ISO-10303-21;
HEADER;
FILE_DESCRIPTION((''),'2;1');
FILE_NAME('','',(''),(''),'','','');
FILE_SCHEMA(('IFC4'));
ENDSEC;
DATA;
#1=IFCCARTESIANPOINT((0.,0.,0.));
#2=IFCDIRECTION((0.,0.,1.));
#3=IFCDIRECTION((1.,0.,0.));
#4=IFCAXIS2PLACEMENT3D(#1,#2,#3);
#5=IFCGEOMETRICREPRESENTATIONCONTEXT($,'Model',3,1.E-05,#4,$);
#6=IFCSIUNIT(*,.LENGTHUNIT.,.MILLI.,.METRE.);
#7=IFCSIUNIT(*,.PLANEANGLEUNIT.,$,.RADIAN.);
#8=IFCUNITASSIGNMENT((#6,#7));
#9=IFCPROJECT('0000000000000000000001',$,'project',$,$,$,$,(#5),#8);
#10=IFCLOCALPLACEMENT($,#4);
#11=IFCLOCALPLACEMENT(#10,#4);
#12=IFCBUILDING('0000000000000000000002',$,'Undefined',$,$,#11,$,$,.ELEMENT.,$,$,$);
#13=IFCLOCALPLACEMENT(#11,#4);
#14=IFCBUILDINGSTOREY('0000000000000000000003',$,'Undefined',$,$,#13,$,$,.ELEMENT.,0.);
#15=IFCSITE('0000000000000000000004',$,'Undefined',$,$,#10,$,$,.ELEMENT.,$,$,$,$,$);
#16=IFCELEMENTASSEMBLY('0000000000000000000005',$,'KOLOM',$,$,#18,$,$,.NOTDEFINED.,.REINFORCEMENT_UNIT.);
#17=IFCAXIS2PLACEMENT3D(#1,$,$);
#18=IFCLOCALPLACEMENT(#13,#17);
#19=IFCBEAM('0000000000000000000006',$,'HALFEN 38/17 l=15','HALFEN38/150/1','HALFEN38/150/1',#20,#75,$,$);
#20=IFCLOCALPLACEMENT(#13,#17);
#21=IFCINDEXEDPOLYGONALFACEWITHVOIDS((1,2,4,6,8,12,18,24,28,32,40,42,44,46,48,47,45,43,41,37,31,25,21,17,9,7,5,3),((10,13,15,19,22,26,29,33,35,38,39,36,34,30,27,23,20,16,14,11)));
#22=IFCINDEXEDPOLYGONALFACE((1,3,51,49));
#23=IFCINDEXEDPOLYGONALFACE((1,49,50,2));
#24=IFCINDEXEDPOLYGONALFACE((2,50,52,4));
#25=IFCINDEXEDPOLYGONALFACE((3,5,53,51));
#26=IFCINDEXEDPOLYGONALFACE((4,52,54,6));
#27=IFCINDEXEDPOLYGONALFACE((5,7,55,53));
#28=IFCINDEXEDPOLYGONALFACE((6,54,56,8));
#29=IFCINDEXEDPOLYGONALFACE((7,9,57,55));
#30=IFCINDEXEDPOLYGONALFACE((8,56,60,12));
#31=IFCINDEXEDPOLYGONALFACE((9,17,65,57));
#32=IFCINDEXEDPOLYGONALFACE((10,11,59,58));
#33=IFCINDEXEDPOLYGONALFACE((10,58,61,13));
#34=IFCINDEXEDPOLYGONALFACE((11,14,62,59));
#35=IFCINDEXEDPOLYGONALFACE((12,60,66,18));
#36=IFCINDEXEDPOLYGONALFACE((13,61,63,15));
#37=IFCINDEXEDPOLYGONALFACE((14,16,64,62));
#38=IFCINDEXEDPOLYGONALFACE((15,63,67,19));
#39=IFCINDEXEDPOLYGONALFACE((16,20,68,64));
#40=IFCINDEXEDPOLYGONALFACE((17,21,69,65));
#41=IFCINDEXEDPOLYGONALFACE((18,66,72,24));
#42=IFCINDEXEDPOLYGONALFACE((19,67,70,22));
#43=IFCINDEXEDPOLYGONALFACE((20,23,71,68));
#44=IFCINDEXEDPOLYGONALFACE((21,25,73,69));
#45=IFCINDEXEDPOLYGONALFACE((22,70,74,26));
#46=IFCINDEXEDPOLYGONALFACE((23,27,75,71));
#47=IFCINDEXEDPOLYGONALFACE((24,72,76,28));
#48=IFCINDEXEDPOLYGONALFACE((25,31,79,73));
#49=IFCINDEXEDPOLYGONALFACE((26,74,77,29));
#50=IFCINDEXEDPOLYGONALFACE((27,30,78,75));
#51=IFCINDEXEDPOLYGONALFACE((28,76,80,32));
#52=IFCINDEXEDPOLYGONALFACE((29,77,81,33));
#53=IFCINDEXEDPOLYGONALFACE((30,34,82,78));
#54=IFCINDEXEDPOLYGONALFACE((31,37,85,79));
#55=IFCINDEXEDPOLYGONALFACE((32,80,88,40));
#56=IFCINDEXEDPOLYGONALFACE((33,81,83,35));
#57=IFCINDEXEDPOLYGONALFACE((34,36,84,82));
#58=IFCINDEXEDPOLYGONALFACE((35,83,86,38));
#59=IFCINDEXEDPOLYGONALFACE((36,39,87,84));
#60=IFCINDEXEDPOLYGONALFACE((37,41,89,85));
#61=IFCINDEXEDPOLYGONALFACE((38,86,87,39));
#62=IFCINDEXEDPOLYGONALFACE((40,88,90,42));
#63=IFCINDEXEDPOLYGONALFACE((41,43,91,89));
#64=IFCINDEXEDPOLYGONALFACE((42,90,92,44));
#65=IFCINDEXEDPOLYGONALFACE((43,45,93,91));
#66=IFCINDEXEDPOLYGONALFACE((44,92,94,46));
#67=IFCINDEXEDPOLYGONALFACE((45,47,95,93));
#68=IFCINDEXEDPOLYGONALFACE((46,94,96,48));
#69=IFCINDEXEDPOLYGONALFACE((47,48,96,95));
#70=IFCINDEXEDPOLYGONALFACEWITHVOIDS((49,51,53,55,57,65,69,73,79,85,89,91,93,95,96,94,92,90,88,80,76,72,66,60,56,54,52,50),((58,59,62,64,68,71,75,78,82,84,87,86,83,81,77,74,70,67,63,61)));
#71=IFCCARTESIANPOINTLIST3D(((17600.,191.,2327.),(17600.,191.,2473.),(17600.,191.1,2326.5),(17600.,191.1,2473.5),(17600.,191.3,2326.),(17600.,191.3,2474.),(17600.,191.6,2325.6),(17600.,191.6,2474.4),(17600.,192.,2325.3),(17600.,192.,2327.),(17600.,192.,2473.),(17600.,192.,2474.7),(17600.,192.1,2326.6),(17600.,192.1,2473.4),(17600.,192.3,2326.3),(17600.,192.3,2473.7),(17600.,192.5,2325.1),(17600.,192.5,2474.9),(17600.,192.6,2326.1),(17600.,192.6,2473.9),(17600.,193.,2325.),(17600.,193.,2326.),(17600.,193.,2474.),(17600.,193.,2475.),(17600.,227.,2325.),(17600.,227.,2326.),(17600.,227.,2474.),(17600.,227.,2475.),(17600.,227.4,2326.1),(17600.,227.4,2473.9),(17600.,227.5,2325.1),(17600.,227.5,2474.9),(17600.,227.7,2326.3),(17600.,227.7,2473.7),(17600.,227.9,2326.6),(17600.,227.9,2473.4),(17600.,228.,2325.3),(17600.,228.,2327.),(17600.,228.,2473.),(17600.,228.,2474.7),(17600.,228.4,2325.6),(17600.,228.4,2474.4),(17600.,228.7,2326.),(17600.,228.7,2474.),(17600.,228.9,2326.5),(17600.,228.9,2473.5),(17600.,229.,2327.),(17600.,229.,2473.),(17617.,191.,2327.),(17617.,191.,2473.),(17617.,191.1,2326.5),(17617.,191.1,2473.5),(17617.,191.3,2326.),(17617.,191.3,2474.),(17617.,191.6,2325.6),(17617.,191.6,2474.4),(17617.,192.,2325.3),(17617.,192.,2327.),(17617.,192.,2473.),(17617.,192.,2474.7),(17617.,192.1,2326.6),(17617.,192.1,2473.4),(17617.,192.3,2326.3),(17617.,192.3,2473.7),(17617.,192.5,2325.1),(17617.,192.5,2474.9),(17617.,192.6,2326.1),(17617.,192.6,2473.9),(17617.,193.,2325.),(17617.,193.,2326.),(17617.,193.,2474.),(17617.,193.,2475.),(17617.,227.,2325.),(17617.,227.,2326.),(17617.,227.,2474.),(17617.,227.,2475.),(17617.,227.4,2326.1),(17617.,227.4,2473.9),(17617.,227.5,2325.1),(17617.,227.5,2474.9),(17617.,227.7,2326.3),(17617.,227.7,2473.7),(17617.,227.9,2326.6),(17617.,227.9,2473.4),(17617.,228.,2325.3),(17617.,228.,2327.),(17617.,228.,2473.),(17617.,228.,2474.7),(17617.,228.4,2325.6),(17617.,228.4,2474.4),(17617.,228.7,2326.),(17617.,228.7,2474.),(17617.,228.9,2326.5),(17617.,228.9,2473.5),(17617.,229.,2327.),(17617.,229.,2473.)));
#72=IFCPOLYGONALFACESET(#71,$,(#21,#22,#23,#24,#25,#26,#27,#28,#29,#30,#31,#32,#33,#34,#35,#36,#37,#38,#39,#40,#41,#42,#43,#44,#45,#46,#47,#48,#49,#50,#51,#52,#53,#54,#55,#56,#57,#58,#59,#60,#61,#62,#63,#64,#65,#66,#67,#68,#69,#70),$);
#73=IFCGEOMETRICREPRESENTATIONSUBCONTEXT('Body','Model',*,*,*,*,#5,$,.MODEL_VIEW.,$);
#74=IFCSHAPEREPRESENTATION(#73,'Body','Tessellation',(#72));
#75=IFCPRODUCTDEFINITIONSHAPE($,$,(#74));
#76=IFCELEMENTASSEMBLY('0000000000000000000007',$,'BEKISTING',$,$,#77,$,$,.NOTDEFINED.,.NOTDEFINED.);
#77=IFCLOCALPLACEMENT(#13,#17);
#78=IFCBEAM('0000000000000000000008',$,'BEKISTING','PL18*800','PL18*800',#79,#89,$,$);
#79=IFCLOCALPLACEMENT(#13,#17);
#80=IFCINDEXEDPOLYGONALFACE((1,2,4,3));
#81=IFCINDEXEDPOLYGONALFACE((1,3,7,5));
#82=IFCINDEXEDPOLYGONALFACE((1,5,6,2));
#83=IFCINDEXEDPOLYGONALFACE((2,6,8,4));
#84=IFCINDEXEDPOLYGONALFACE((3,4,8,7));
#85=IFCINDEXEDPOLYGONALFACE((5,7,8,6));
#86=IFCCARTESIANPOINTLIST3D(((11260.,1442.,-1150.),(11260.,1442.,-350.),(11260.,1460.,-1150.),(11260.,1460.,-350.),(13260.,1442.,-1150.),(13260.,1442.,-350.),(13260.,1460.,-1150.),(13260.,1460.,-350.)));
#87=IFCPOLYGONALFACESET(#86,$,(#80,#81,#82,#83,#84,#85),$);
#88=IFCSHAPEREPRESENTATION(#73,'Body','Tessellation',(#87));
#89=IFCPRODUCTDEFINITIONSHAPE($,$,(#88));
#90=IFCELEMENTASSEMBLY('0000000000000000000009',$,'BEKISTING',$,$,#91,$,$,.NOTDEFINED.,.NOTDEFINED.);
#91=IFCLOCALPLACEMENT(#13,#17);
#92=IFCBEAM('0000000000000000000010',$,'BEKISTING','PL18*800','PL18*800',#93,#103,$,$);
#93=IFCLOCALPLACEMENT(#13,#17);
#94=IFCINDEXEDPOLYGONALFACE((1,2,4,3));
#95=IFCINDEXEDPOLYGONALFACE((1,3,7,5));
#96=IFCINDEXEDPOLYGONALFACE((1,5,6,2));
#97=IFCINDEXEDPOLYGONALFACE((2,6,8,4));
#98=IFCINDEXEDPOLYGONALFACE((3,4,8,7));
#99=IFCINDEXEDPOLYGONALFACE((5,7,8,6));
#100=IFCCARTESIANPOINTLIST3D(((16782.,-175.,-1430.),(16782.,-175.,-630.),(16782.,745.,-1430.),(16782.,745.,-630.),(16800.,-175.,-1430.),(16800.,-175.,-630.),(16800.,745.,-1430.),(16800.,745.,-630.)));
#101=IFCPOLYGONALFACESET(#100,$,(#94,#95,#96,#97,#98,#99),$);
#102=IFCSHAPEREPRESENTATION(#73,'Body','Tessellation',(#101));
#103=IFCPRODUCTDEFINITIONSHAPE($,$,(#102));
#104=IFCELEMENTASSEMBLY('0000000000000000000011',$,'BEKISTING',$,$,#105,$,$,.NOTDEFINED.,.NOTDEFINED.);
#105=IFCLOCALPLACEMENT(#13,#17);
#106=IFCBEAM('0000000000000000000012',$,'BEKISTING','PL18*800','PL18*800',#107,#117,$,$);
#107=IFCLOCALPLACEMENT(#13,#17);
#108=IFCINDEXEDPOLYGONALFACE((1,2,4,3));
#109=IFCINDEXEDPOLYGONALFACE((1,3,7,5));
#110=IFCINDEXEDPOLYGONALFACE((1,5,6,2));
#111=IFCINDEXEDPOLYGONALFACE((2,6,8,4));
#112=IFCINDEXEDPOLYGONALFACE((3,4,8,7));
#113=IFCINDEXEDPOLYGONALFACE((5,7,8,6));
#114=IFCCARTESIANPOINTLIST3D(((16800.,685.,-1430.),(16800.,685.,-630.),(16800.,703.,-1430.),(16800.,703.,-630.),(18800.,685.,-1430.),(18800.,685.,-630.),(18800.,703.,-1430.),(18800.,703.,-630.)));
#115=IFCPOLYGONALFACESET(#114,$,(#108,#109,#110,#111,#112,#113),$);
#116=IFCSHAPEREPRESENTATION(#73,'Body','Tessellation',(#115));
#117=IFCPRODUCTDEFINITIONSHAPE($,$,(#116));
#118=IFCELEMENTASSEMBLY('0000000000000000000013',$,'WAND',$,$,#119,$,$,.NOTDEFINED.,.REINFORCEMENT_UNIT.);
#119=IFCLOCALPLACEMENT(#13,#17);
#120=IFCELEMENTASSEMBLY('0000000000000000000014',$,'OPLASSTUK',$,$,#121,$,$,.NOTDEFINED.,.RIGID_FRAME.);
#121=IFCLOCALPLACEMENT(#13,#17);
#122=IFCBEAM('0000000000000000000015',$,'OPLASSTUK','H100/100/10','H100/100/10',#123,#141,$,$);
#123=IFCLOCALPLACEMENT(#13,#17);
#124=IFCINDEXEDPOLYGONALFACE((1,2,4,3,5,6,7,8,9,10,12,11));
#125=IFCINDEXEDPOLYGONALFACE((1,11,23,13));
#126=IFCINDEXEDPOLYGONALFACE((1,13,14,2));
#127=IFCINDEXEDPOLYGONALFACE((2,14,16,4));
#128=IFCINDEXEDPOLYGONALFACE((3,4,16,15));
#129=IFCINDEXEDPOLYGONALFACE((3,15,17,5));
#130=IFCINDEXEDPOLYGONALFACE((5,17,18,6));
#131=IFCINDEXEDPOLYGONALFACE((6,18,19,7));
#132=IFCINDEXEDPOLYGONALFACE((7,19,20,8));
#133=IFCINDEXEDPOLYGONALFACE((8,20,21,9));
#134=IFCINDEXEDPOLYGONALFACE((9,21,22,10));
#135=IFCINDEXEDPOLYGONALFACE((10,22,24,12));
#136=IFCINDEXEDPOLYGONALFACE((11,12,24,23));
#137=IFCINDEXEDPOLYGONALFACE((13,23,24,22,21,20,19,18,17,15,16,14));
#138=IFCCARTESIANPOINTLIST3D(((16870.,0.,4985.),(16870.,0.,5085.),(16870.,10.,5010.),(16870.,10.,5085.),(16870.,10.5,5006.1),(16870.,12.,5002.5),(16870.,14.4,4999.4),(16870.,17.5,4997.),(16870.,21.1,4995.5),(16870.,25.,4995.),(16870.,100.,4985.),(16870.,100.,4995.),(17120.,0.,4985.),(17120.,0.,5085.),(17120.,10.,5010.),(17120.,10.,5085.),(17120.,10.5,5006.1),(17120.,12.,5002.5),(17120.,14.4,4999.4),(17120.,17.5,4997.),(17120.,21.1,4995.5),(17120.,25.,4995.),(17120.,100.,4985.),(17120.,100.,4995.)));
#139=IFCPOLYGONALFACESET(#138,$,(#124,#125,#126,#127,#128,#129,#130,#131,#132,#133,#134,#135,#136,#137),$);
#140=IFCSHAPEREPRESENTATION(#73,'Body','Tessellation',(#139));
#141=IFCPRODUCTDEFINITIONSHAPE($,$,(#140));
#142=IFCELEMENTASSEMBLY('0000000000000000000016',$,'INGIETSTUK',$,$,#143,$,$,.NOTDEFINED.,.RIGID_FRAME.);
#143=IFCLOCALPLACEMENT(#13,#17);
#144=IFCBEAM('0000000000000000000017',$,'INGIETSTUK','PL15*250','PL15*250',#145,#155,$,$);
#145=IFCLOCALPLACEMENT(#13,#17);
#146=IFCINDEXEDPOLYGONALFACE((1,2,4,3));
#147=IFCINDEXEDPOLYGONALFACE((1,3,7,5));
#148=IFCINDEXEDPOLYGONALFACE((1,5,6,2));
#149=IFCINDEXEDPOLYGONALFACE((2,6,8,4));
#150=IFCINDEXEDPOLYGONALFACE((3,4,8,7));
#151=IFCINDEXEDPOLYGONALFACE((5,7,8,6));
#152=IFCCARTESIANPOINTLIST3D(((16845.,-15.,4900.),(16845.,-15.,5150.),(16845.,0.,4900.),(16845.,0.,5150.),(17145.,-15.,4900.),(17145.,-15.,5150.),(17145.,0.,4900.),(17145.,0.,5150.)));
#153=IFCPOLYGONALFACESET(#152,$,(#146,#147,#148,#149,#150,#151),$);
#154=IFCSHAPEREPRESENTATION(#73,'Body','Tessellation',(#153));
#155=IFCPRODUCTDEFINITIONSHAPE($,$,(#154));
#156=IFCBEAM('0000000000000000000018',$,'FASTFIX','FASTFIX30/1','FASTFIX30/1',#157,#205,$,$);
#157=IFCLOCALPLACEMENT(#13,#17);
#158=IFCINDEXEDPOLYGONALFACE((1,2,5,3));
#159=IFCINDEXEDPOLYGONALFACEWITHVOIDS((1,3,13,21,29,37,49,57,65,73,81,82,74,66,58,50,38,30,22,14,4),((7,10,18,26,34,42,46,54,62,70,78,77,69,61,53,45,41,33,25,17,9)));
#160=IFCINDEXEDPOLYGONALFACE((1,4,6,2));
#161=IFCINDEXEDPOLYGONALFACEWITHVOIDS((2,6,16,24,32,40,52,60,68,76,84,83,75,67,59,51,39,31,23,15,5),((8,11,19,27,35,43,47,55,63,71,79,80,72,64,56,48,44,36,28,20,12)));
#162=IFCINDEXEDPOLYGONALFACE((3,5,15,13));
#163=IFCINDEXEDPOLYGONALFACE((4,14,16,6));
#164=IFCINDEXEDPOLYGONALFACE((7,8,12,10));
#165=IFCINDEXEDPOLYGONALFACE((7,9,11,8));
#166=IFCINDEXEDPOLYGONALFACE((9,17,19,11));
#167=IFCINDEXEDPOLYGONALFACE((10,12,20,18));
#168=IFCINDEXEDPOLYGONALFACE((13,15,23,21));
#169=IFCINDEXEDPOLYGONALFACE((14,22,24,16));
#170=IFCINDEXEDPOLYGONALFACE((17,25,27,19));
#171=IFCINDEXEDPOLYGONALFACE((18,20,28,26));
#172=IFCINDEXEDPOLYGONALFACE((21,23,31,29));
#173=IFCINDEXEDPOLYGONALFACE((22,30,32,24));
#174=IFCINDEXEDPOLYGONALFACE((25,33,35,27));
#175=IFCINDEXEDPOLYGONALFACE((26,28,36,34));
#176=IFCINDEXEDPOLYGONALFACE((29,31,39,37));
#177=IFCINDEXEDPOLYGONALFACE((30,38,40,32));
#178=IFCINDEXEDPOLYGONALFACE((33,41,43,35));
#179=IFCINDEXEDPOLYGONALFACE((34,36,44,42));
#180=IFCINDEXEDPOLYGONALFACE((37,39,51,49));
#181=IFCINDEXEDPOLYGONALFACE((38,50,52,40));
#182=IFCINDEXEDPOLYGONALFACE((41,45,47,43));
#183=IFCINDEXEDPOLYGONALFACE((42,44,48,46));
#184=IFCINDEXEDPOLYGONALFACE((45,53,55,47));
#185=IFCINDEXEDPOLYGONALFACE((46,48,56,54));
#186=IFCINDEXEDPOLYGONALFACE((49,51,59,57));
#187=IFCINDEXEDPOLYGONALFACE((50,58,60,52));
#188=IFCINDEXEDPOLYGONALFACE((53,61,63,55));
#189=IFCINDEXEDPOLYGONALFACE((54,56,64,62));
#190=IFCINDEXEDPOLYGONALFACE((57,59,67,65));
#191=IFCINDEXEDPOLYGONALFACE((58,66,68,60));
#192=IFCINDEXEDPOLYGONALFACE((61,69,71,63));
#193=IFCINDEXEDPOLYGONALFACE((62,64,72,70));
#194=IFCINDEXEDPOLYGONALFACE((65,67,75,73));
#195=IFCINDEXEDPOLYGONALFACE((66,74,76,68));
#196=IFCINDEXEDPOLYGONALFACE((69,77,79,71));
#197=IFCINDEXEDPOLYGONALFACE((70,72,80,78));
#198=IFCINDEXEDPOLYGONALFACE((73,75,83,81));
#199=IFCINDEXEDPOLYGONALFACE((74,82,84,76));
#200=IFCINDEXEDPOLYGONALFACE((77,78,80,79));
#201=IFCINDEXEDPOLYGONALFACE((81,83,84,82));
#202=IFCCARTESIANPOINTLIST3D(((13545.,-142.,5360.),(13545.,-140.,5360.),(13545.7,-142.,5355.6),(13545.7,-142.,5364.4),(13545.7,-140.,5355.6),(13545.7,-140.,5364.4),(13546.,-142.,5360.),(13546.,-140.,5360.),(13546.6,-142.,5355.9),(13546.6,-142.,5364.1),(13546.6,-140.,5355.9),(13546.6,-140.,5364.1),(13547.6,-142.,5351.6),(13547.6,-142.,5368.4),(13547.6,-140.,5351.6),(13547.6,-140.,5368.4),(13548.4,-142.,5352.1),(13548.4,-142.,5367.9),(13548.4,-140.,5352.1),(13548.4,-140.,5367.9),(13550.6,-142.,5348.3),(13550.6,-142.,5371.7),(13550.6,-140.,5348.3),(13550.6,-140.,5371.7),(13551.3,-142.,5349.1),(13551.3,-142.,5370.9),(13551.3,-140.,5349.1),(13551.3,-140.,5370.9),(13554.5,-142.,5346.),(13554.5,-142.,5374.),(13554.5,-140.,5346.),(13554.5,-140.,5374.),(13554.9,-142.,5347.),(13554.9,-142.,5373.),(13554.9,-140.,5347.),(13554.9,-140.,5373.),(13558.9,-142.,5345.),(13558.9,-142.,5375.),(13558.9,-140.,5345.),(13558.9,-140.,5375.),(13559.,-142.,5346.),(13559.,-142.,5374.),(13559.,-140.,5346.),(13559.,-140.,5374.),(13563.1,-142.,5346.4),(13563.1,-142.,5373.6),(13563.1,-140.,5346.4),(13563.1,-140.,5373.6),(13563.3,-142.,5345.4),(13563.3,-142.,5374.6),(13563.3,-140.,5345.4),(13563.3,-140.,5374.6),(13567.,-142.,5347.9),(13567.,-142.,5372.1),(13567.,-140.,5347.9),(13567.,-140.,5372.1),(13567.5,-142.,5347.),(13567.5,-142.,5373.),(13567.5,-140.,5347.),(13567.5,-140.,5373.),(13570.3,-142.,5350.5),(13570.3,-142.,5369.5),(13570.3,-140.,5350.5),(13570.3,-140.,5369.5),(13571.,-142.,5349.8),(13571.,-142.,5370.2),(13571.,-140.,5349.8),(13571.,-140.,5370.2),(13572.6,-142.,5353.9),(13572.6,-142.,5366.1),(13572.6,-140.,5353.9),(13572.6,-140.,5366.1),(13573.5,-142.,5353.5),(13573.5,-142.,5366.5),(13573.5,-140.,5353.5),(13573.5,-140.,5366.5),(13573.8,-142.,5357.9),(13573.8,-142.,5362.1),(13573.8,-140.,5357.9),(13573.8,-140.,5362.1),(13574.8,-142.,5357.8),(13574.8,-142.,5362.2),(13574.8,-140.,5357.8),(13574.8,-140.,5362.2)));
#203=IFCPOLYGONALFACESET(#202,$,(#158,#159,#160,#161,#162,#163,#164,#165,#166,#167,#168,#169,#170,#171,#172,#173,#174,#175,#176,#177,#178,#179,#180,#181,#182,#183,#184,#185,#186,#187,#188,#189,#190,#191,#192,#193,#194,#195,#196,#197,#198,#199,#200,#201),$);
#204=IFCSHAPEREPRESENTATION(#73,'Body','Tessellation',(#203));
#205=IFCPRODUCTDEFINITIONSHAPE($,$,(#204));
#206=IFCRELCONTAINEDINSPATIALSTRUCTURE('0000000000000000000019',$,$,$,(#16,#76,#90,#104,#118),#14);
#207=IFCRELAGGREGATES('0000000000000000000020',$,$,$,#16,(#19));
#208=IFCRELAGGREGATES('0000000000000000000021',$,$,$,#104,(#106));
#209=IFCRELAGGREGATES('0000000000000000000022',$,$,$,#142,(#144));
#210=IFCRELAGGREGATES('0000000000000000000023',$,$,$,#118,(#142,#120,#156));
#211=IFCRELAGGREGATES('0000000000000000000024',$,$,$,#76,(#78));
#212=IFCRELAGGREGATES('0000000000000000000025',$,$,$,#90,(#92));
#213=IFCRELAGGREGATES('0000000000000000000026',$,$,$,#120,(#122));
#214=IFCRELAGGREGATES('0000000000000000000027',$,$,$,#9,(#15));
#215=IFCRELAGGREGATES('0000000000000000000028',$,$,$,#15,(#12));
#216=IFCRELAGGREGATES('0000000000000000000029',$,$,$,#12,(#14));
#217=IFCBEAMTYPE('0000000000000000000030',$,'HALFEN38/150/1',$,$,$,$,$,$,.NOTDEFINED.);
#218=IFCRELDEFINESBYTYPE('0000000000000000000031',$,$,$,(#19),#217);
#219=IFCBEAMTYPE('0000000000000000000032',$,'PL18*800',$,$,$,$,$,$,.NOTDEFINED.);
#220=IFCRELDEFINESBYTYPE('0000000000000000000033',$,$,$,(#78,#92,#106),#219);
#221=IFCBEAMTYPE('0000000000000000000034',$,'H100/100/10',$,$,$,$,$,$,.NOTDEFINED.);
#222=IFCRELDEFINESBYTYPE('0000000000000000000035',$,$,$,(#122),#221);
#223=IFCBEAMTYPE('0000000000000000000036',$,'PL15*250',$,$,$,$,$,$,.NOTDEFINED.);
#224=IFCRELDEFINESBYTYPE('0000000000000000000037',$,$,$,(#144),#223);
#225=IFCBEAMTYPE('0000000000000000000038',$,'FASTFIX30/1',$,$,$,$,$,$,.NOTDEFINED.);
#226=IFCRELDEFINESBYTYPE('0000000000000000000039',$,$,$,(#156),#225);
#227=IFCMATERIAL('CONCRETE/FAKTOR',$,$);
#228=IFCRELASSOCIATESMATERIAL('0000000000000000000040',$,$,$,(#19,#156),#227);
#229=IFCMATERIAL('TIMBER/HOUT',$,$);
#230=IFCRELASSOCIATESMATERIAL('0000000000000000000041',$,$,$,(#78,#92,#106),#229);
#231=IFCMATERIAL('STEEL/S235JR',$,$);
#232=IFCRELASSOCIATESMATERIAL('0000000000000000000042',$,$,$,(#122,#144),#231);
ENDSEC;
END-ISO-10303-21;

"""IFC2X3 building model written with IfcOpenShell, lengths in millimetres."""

from ifc_helpers import new_model, si_unit, frame, frame_2d, origin_with_axes, place, context, subcontext, project, spatial, rectangle, hollow_rectangle, hollow_circle, l_section, extrude, material, type_object, element, aggregate, save


model = new_model("IFC2X3")

# Units and contexts
model_context = context("Model", 3, precision=1e-05, world=origin_with_axes())
body_context = subcontext(model_context, "Body", "Model", "MODEL_VIEW")
ifc_project = project(units=[si_unit("LENGTHUNIT", "METRE", prefix="MILLI"), si_unit("PLANEANGLEUNIT", "RADIAN")], contexts=[model_context])

# Site, building, storey
site_placement = place(None, origin_with_axes())
site = spatial("IfcSite", under=ifc_project, at=site_placement, Name="Undefined", CompositionType="ELEMENT")
building_placement = place(site_placement, origin_with_axes())
building = spatial("IfcBuilding", under=site, at=building_placement, Name="Undefined", CompositionType="ELEMENT")
storey_placement = place(building_placement, origin_with_axes())
storey = spatial("IfcBuildingStorey", under=building, at=storey_placement, Name="Undefined", CompositionType="ELEMENT", Elevation=0.0)

# Element assemblies, beams
ifc_material_1 = material(Name="STEEL/S235JR")
ifc_material_2 = material(Name="CONCRETE/FAKTOR")
assembly_1_placement = place(storey_placement, origin_with_axes())
assembly_1 = element("IfcElementAssembly", 1, at=assembly_1_placement, inside=storey, Name="KOLOM", AssemblyPlace="NOTDEFINED", PredefinedType="REINFORCEMENT_UNIT")
beam_type_1 = type_object("IfcBeamType", Name="HALFEN38/150/1", PredefinedType="NOTDEFINED")
beam_1_placement = place(assembly_1_placement, frame((17600.0, 210.0, 2400.0), z_axis=(0.0, 1.0, 0.0), x_axis=(1.0, 0.0, 0.0)))
beam_1 = element("IfcBeam", 2, at=beam_1_placement, type_object=beam_type_1, material=ifc_material_2, Name="HALFEN 38/17 l=15", Description="HALFEN38/150/1", ObjectType="HALFEN38/150/1", context=body_context, shape_type="SweptSolid", body=[
    extrude(hollow_rectangle(XDim=150.0, YDim=38.0, WallThickness=1.0, InnerFilletRadius=1.0, OuterFilletRadius=2.0, at=frame_2d((0.0, 0.0), x_axis=(1.0, 0.0))), frame((17.0, 0.0, 0.0), z_axis=(-1.0, 0.0, 0.0), x_axis=(0.0, -1.0, 0.0)), (0.0, 0.0, 1.0), 17.0),
])
aggregate(assembly_1, [beam_1])
assembly_2_placement = place(storey_placement, origin_with_axes())
assembly_2 = element("IfcElementAssembly", 3, at=assembly_2_placement, inside=storey, Name="BEKISTING", AssemblyPlace="NOTDEFINED", PredefinedType="NOTDEFINED")
ifc_material_3 = material(Name="TIMBER/HOUT")
beam_type_2 = type_object("IfcBeamType", Name="PL18*800", PredefinedType="NOTDEFINED")
beam_2_placement = place(assembly_2_placement, frame((13260.0, 1451.0, -750.0), z_axis=(0.0, 0.0, 1.0), x_axis=(-1.0, 0.0, 0.0)))
beam_2 = element("IfcBeam", 4, at=beam_2_placement, type_object=beam_type_2, material=ifc_material_3, Name="BEKISTING", Description="PL18*800", ObjectType="PL18*800", context=body_context, shape_type="SweptSolid", body=[
    extrude(rectangle(XDim=18.0, YDim=800.0, at=frame_2d((0.0, 0.0), x_axis=(1.0, 0.0))), frame((2000.0, 0.0, 0.0), z_axis=(-1.0, 0.0, 0.0), x_axis=(0.0, -1.0, 0.0)), (0.0, 0.0, 1.0), 2000.0),
])
assembly_3_placement = place(storey_placement, origin_with_axes())
assembly_3 = element("IfcElementAssembly", 5, at=assembly_3_placement, inside=storey, Name="BEKISTING", AssemblyPlace="NOTDEFINED", PredefinedType="NOTDEFINED")
beam_3_placement = place(assembly_3_placement, frame((16791.0, -175.0, -1030.0), z_axis=(0.0, 0.0, -1.0), x_axis=(0.0, 1.0, 0.0)))
beam_3 = element("IfcBeam", 6, at=beam_3_placement, type_object=beam_type_2, material=ifc_material_3, Name="BEKISTING", Description="PL18*800", ObjectType="PL18*800", context=body_context, shape_type="SweptSolid", body=[
    extrude(rectangle(XDim=18.0, YDim=800.0, at=frame_2d((0.0, 0.0), x_axis=(1.0, 0.0))), frame((920.0, 0.0, 0.0), z_axis=(-1.0, 0.0, 0.0), x_axis=(0.0, -1.0, 0.0)), (0.0, 0.0, 1.0), 920.0),
])
assembly_4_placement = place(storey_placement, origin_with_axes())
assembly_4 = element("IfcElementAssembly", 7, at=assembly_4_placement, inside=storey, Name="BEKISTING", AssemblyPlace="NOTDEFINED", PredefinedType="NOTDEFINED")
beam_4_placement = place(assembly_4_placement, frame((16800.0, 694.0, -1030.0), z_axis=(0.0, 0.0, 1.0), x_axis=(1.0, 0.0, 0.0)))
beam_4 = element("IfcBeam", 8, at=beam_4_placement, type_object=beam_type_2, material=ifc_material_3, Name="BEKISTING", Description="PL18*800", ObjectType="PL18*800", context=body_context, shape_type="SweptSolid", body=[
    extrude(rectangle(XDim=18.0, YDim=800.0, at=frame_2d((0.0, 0.0), x_axis=(1.0, 0.0))), frame((2000.0, 0.0, 0.0), z_axis=(-1.0, 0.0, 0.0), x_axis=(0.0, -1.0, 0.0)), (0.0, 0.0, 1.0), 2000.0),
])
aggregate(assembly_4, [beam_4])

# Element assemblies, beams
assembly_5_placement = place(storey_placement, origin_with_axes())
assembly_5 = element("IfcElementAssembly", 9, at=assembly_5_placement, inside=storey, Name="WAND", AssemblyPlace="NOTDEFINED", PredefinedType="REINFORCEMENT_UNIT")
assembly_6_placement = place(assembly_5_placement, origin_with_axes())
assembly_6 = element("IfcElementAssembly", 10, at=assembly_6_placement, Name="OPLASSTUK", AssemblyPlace="NOTDEFINED", PredefinedType="RIGID_FRAME")
beam_type_3 = type_object("IfcBeamType", Name="H100/100/10", PredefinedType="NOTDEFINED")
beam_5_placement = place(assembly_6_placement, frame((17120.0, 50.0, 5035.0), z_axis=(0.0, 0.0, 1.0), x_axis=(-1.0, 0.0, 0.0)))
beam_5 = element("IfcBeam", 11, at=beam_5_placement, type_object=beam_type_3, material=ifc_material_1, Name="OPLASSTUK", Description="H100/100/10", ObjectType="H100/100/10", context=body_context, shape_type="SweptSolid", body=[
    extrude(l_section(Depth=100.0, Width=100.0, Thickness=10.0, FilletRadius=15.0, at=frame_2d((0.0, 0.0), x_axis=(1.0, 0.0))), frame((250.0, 0.0, 0.0), z_axis=(-1.0, 0.0, 0.0), x_axis=(0.0, -1.0, 0.0)), (0.0, 0.0, 1.0), 250.0),
])
assembly_7_placement = place(assembly_5_placement, origin_with_axes())
assembly_7 = element("IfcElementAssembly", 12, at=assembly_7_placement, Name="INGIETSTUK", AssemblyPlace="NOTDEFINED", PredefinedType="RIGID_FRAME")
beam_type_4 = type_object("IfcBeamType", Name="PL15*250", PredefinedType="NOTDEFINED")
beam_6_placement = place(assembly_7_placement, frame((16845.0, -7.5, 5025.0), z_axis=(0.0, 0.0, 1.0), x_axis=(1.0, 0.0, 0.0)))
beam_6 = element("IfcBeam", 13, at=beam_6_placement, type_object=beam_type_4, material=ifc_material_1, Name="INGIETSTUK", Description="PL15*250", ObjectType="PL15*250", context=body_context, shape_type="SweptSolid", body=[
    extrude(rectangle(XDim=15.0, YDim=250.0, at=frame_2d((0.0, 0.0), x_axis=(1.0, 0.0))), frame((300.0, 0.0, 0.0), z_axis=(-1.0, 0.0, 0.0), x_axis=(0.0, -1.0, 0.0)), (0.0, 0.0, 1.0), 300.0),
])
aggregate(assembly_7, [beam_6])
beam_type_5 = type_object("IfcBeamType", Name="FASTFIX30/1", PredefinedType="NOTDEFINED")
beam_7_placement = place(assembly_5_placement, frame((13560.0, -140.0, 5360.0), z_axis=(0.0, 0.0, 1.0), x_axis=(0.0, -1.0, 0.0)))
beam_7 = element("IfcBeam", 14, at=beam_7_placement, type_object=beam_type_5, material=ifc_material_2, Name="FASTFIX", Description="FASTFIX30/1", ObjectType="FASTFIX30/1", context=body_context, shape_type="SweptSolid", body=[
    extrude(hollow_circle(Radius=15.0, WallThickness=1.0, at=frame_2d((0.0, 0.0), x_axis=(1.0, 0.0))), frame((2.0, 0.0, 0.0), z_axis=(-1.0, 0.0, 0.0), x_axis=(0.0, -1.0, 0.0)), (0.0, 0.0, 1.0), 2.0),
])
aggregate(assembly_5, [assembly_7, assembly_6, beam_7])

aggregate(assembly_2, [beam_2])
aggregate(assembly_3, [beam_3])

aggregate(assembly_6, [beam_5])

save(model, "model.ifc")
